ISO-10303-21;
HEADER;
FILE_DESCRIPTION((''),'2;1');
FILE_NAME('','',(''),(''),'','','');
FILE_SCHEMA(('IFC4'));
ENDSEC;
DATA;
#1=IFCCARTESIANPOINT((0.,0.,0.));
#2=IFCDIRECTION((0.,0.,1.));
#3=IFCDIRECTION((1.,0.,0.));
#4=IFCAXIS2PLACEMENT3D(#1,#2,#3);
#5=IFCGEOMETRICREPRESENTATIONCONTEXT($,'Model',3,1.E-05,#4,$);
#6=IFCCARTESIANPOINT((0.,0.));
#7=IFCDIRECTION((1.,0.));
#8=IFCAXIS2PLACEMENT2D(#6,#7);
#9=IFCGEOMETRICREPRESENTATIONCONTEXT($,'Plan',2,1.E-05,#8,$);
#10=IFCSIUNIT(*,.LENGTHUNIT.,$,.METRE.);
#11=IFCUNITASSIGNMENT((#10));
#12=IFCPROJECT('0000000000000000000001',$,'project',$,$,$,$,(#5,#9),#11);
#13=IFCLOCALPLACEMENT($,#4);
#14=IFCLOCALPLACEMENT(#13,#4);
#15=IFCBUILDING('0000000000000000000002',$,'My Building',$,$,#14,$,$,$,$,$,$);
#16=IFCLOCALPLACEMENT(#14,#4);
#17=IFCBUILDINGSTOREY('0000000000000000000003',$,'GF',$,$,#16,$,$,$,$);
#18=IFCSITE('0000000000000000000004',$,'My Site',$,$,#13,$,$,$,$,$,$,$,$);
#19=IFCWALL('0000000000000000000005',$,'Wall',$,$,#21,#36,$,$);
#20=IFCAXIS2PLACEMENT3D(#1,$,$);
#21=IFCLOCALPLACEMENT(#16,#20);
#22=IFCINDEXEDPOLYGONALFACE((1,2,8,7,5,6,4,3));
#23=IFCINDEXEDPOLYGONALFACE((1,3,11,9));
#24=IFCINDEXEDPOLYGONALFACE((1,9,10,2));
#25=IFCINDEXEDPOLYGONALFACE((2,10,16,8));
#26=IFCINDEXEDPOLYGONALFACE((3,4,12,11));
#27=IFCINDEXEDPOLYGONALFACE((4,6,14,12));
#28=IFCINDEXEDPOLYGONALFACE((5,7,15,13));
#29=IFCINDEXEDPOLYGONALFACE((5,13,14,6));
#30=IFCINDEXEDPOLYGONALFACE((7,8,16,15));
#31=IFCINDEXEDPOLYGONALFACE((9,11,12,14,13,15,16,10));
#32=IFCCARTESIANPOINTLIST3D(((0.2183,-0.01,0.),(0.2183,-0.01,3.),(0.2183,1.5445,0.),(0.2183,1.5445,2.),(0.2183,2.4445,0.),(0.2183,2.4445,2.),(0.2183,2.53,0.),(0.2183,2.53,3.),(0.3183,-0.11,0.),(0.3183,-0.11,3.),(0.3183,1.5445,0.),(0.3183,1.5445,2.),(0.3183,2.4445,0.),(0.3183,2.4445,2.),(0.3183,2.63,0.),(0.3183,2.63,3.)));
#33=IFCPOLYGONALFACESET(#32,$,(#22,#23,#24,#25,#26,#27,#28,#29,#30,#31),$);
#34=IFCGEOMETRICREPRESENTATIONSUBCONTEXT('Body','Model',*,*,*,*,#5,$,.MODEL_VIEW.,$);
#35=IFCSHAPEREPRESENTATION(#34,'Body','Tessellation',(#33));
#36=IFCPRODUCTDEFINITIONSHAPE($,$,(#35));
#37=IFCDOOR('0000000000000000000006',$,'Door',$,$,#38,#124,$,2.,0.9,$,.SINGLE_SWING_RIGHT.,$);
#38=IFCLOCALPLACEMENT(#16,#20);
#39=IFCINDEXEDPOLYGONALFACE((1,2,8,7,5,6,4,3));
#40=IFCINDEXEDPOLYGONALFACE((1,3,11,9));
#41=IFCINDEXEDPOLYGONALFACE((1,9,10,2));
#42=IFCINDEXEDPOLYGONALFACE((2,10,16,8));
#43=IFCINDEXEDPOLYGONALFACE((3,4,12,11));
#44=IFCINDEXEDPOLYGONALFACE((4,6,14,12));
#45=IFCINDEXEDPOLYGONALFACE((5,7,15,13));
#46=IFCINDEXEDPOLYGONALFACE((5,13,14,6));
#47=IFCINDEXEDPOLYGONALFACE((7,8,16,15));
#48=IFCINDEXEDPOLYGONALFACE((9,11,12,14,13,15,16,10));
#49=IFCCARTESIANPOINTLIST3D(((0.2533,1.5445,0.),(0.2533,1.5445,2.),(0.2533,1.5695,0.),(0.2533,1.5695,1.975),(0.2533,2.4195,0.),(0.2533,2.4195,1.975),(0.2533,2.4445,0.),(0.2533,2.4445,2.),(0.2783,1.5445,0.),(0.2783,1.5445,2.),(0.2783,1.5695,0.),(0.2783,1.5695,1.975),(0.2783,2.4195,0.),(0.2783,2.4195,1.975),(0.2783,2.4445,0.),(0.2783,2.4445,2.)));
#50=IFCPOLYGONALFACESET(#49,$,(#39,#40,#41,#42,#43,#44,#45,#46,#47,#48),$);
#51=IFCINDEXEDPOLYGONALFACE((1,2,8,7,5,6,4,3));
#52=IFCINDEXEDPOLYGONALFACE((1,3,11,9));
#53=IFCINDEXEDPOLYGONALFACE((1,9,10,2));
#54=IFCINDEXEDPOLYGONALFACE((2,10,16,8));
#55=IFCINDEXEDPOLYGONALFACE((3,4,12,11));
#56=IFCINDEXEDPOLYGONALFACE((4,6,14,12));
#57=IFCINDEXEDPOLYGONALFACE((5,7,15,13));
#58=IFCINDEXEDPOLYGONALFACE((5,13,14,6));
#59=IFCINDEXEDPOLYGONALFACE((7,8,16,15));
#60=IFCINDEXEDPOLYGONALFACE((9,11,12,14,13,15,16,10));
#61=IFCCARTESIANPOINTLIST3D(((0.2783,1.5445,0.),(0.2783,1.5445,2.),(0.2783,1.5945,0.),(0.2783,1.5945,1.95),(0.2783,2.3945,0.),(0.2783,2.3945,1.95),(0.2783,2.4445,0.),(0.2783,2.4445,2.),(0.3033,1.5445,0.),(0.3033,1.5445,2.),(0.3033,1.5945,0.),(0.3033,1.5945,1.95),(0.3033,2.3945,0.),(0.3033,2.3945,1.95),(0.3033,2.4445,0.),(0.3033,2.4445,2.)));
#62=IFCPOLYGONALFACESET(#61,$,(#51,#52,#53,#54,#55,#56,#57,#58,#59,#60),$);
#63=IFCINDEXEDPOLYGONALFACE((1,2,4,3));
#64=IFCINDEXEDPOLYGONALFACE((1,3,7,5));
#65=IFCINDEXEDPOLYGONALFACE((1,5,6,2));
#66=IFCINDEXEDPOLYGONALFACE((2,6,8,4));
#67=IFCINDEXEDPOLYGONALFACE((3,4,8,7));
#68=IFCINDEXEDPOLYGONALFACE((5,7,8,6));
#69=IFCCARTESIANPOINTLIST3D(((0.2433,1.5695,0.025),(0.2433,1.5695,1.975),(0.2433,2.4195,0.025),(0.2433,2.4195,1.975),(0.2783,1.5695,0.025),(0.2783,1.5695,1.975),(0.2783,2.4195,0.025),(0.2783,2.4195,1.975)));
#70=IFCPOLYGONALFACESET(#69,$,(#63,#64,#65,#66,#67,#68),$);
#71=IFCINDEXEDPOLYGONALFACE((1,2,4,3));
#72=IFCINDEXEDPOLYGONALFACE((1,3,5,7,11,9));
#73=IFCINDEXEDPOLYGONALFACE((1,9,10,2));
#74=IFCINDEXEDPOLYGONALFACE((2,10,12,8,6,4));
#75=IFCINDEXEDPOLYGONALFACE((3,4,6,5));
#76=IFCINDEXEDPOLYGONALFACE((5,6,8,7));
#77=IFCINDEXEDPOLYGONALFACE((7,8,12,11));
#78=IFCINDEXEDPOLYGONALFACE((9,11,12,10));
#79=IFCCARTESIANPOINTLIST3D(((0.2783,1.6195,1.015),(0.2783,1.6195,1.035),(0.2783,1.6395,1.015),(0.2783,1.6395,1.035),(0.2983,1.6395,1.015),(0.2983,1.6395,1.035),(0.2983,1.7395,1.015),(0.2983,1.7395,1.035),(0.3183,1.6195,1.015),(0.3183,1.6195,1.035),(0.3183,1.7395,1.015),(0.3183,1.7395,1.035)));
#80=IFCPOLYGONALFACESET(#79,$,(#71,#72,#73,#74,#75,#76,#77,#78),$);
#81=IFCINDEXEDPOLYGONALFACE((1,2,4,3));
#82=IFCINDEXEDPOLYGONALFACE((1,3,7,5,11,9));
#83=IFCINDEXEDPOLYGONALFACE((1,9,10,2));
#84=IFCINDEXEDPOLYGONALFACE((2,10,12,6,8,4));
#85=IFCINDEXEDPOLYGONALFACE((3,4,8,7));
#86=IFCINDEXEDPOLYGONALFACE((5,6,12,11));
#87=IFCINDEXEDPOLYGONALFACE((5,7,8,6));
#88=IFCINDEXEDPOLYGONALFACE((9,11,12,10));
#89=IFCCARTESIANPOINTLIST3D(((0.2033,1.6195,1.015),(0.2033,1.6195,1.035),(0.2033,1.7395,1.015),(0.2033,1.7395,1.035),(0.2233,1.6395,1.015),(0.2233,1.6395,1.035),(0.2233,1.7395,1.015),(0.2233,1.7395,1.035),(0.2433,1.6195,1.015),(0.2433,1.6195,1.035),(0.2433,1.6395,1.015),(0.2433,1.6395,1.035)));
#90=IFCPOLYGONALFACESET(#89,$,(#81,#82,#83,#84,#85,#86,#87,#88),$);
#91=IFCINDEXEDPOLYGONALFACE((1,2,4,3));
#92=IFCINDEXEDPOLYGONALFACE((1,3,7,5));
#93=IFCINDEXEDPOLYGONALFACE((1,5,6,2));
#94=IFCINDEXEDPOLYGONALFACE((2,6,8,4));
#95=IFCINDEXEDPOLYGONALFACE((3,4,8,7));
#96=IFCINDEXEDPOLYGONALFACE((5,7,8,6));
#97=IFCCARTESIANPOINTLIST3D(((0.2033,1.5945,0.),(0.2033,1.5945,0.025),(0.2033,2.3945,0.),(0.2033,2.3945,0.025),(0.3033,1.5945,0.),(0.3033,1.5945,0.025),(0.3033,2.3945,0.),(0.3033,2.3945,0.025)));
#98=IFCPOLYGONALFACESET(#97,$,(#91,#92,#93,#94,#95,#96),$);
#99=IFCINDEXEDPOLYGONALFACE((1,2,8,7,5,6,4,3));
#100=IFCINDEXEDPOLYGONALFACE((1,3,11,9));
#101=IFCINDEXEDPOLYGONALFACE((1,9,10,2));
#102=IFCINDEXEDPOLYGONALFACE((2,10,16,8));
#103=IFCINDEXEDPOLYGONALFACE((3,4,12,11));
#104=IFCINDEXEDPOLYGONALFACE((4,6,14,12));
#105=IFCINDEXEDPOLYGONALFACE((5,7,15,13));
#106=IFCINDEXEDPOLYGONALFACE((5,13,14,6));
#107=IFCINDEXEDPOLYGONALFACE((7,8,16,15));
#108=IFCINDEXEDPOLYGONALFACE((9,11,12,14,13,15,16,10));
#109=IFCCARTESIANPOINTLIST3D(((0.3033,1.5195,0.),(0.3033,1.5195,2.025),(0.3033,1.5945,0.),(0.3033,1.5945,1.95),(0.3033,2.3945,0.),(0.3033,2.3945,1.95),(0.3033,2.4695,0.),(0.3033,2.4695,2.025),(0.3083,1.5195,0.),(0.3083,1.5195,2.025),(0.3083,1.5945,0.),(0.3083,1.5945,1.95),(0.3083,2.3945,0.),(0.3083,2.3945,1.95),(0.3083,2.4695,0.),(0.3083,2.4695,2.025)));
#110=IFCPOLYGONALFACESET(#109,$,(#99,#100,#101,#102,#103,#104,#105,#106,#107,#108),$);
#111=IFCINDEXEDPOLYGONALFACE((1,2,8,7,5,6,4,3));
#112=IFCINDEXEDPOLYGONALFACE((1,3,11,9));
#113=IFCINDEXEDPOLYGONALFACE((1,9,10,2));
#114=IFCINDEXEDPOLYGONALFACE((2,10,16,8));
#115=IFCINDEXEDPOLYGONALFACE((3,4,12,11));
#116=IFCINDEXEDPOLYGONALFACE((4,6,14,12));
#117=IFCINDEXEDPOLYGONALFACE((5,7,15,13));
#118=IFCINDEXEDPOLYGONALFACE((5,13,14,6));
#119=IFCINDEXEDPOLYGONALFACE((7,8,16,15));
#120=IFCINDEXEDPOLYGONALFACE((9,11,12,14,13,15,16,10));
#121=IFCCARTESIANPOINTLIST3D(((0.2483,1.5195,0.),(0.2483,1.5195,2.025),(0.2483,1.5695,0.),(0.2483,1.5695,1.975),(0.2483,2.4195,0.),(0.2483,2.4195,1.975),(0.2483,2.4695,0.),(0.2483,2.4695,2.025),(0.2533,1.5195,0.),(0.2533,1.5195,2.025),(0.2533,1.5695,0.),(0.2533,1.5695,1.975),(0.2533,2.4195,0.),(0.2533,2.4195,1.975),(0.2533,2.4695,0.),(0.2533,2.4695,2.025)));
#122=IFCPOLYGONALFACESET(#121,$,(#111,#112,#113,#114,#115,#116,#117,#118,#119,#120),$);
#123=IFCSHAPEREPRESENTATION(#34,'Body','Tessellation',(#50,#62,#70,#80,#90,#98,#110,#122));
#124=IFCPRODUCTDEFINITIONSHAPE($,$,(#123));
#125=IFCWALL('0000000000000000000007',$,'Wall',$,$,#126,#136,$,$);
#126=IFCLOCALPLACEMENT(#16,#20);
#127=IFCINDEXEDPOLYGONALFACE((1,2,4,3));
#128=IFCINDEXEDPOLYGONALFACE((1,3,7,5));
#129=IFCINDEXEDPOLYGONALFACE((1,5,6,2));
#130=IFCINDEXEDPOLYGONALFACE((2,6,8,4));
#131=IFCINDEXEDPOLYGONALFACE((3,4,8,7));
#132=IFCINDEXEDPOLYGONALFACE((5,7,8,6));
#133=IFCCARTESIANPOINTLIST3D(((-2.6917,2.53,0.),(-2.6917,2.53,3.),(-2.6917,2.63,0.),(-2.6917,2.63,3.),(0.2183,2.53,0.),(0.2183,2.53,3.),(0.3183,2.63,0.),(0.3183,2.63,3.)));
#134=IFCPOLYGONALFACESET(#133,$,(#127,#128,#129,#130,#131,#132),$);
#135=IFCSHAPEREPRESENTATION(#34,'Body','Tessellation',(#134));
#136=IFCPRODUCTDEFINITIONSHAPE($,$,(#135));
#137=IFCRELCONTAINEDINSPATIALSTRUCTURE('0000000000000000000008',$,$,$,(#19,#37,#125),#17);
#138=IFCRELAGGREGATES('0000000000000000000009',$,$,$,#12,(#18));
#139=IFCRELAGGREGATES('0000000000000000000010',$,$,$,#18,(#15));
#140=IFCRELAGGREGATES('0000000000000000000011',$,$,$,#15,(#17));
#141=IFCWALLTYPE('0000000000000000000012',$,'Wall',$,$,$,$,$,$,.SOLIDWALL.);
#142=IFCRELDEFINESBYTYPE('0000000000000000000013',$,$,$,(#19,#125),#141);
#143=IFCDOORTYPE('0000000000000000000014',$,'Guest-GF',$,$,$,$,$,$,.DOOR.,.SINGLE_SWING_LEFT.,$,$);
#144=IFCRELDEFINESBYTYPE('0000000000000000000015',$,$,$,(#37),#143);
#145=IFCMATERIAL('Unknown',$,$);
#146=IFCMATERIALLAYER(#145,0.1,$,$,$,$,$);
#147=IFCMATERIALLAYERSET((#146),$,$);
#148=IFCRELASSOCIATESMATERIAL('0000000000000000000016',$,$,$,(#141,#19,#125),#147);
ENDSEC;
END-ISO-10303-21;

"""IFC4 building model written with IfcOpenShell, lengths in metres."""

from ifc_helpers import new_model, entity, si_unit, frame, origin_with_axes, origin_2d_with_axis, place, context, subcontext, project, spatial, line, indexed_curve, outline, extrude, shape, source, transform, mapped, material, layer, layer_set, layer_usage, type_object, type_shapes, element, fill, save


model = new_model("IFC4")

# Units and contexts
model_context = context("Model", 3, precision=1e-05, world=origin_with_axes())
plan_context = context("Plan", 2, precision=1e-05, world=origin_2d_with_axis())
body_context_1 = subcontext(model_context, "Body", "Model", "MODEL_VIEW")
body_context_2 = subcontext(plan_context, "Body", "Plan", "PLAN_VIEW")
ifc_project = project(units=[si_unit("LENGTHUNIT", "METRE")], contexts=[model_context, plan_context])

# Site, building, storey
site_placement = place(None, origin_with_axes())
site = spatial("IfcSite", under=ifc_project, at=site_placement, Name="My Site")
building_placement = place(site_placement, origin_with_axes())
building = spatial("IfcBuilding", under=site, at=building_placement, Name="My Building")
storey_placement = place(building_placement, origin_with_axes())
storey = spatial("IfcBuildingStorey", under=building, at=storey_placement, Name="GF")

# Shared definitions
ifc_material = material(Name="Unknown")

# Shared definitions
ifc_layer_1 = layer(ifc_material, 0.1)
ifc_layer_set_1 = layer_set([ifc_layer_1])
wall_type = type_object("IfcWallType", Name="Wall", PredefinedType="SOLIDWALL", material=ifc_layer_set_1)

# Wall, opening, door
ifc_layer_usage_1 = layer_usage(ifc_layer_set_1, "AXIS2", "POSITIVE", 0.0)
wall_1_placement = place(storey_placement, frame((0.3183, -0.11, 0.0), z_axis=(0.0, 0.0, 1.0), x_axis=(0.0, 1.0, 0.0)))
wall_1 = element("IfcWall", 1, at=wall_1_placement, inside=storey, type_object=wall_type, material=ifc_layer_usage_1, Name="Wall", context=body_context_1, shape_type="SweptSolid", body=[
    extrude(outline(indexed_curve([(0.0, 0.0), (0.1, 0.1), (2.64, 0.1), (2.74, 0.0)], segments=[line(1, 2, 3, 4, 1)])), origin_with_axes(), (0.0, 0.0, 1.0), 3.0),
])
shared_shape_1 = source(origin_with_axes(), body_context_1, "Body", "SweptSolid", [
    extrude(outline(indexed_curve([(0.0, 0.0), (0.9, 0.0), (0.9, 2.0), (0.0, 2.0)], segments=[line(1, 2, 3, 4, 1)])), frame((0.0, -0.6, 0.0), z_axis=(0.0, -1.0, 0.0), x_axis=(1.0, 0.0, 0.0)), (0.0, 0.0, -1.0), 1.2),
])
opening_1_placement = place(wall_1_placement, frame((1.6545, 0.015, 0.0), z_axis=(0.0, 0.0, 1.0), x_axis=(1.0, 0.0, 0.0)))
opening_1 = element("IfcOpeningElement", 2, at=opening_1_placement, cuts=wall_1, PredefinedType="OPENING", context=body_context_1, shape_type="MappedRepresentation", body=[
    mapped(shared_shape_1, transform((0.0, 0.0, 0.0), x_axis=(1.0, 0.0, 0.0), y_axis=(0.0, 1.0, 0.0), z_axis=(0.0, 0.0, 1.0), scale=1.0)),
])
door_type_1 = type_object("IfcDoorType", Name="Guest-GF", OperationType="SINGLE_SWING_LEFT", PredefinedType="DOOR")
shared_shape_2 = source(origin_with_axes(), body_context_1, "Body", "SweptSolid", [
    extrude(outline(indexed_curve([(0.0, 0.0), (0.0, 2.0), (0.9, 2.0), (0.9, 0.0), (0.875, 0.0), (0.875, 1.975), (0.025, 1.975), (0.025, 0.0)], segments=[line(1, 2, 3, 4, 5, 6, 7, 8, 1)])), frame((0.0, 0.025, 0.0), z_axis=(0.0, -1.0, 0.0), x_axis=(1.0, 0.0, 0.0)), (0.0, 0.0, -1.0), 0.025),
    extrude(outline(indexed_curve([(0.0, 0.0), (0.0, 2.0), (0.9, 2.0), (0.9, 0.0), (0.85, 0.0), (0.85, 1.95), (0.05, 1.95), (0.05, 0.0)], segments=[line(1, 2, 3, 4, 5, 6, 7, 8, 1)])), frame((0.0, 0.0, 0.0), z_axis=(0.0, -1.0, 0.0), x_axis=(1.0, 0.0, 0.0)), (0.0, 0.0, -1.0), 0.025),
    extrude(outline(indexed_curve([(0.0, 0.0), (0.85, 0.0), (0.85, 0.035), (0.0, 0.035)], segments=[line(1, 2, 3, 4, 1)])), frame((0.025, 0.025, 0.025), z_axis=(0.0, 0.0, 1.0), x_axis=(1.0, 0.0, 0.0)), (0.0, 0.0, 1.0), 1.95),
    extrude(outline(indexed_curve([(0.0, 0.0), (0.0, -0.04), (0.12, -0.04), (0.12, -0.02), (0.02, -0.02), (0.02, 0.0)], segments=[line(1, 2, 3, 4, 5, 6, 1)])), frame((0.075, 0.025, 1.015), z_axis=(0.0, 0.0, 1.0), x_axis=(1.0, 0.0, 0.0)), (0.0, 0.0, 1.0), 0.02),
    extrude(outline(indexed_curve([(0.0, 0.0), (0.0, 0.04), (0.12, 0.04), (0.12, 0.02), (0.02, 0.02), (0.02, 0.0)], segments=[line(1, 2, 3, 4, 5, 6, 1)])), frame((0.075, 0.06, 1.015), z_axis=(0.0, 0.0, 1.0), x_axis=(1.0, 0.0, 0.0)), (0.0, 0.0, 1.0), 0.02),
    extrude(outline(indexed_curve([(0.0, 0.0), (0.8, 0.0), (0.8, 0.1), (0.0, 0.1)], segments=[line(1, 2, 3, 4, 1)])), frame((0.05, 0.0, 0.0), z_axis=(0.0, 0.0, 1.0), x_axis=(1.0, 0.0, 0.0)), (0.0, 0.0, 1.0), 0.025),
    extrude(outline(indexed_curve([(0.0, 0.0), (0.0, 2.025), (0.95, 2.025), (0.95, 0.0), (0.875, 0.0), (0.875, 1.95), (0.075, 1.95), (0.075, 0.0)], segments=[line(1, 2, 3, 4, 5, 6, 7, 8, 1)])), frame((-0.025, -0.005, 0.0), z_axis=(0.0, -1.0, 0.0), x_axis=(1.0, 0.0, 0.0)), (0.0, 0.0, -1.0), 0.005),
    extrude(outline(indexed_curve([(0.0, 0.0), (0.0, 2.025), (0.95, 2.025), (0.95, 0.0), (0.9, 0.0), (0.9, 1.975), (0.05, 1.975), (0.05, 0.0)], segments=[line(1, 2, 3, 4, 5, 6, 7, 8, 1)])), frame((-0.025, 0.05, 0.0), z_axis=(0.0, -1.0, 0.0), x_axis=(1.0, 0.0, 0.0)), (0.0, 0.0, -1.0), 0.005),
])
shared_shape_3 = source(origin_with_axes(), body_context_2, "Body", "Curve2D", [
    entity("IfcIndexedPolyCurve", entity("IfcCartesianPointList2D", [[0.0, 0.0], [0.0, 0.05], [0.025, 0.05], [0.025, 0.025], [0.05, 0.025], [0.05, 0.0]]), [entity("IfcLineIndex", [1, 2, 3, 4, 5, 6, 1])]),
    entity("IfcIndexedPolyCurve", entity("IfcCartesianPointList2D", [[0.9, 0.0], [0.9, 0.05], [0.875, 0.05], [0.875, 0.025], [0.85, 0.025], [0.85, 0.0]]), [entity("IfcLineIndex", [1, 2, 3, 4, 5, 6, 1])]),
    entity("IfcTrimmedCurve", entity("IfcEllipse", entity("IfcAxis2Placement2D", entity("IfcCartesianPoint", [0.84, 0.05]), entity("IfcDirection", [1.0, 0.0])), 0.815, 0.85), [entity("IfcCartesianPoint", [0.84, 0.9])], [entity("IfcCartesianPoint", [0.025, 0.05])], True, "CARTESIAN"),
    entity("IfcIndexedPolyCurve", entity("IfcCartesianPointList2D", [[0.875, 0.05], [0.84, 0.05], [0.84, 0.9], [0.875, 0.9]]), [entity("IfcLineIndex", [1, 2, 3, 4, 1])]),
])
type_shapes(door_type_1, [shared_shape_2, shared_shape_3])
door_1_placement = place(opening_1_placement, frame((0.0, 0.0, 0.0), z_axis=(0.0, 0.0, 1.0), x_axis=(1.0, 0.0, 0.0)))
door_1 = element("IfcDoor", 3, at=door_1_placement, inside=storey, type_object=door_type_1, Name="Door", OperationType="SINGLE_SWING_RIGHT", OverallHeight=2.0, OverallWidth=0.9, shapes=[
    shape(body_context_1, "Body", "MappedRepresentation", [mapped(shared_shape_2, transform((0.0, 0.0, 0.0), x_axis=(1.0, 0.0, 0.0), y_axis=(0.0, 1.0, 0.0), z_axis=(0.0, 0.0, 1.0), scale=1.0))]),
    shape(body_context_2, "Body", "MappedRepresentation", [mapped(shared_shape_3, transform((0.0, 0.0, 0.0), x_axis=(1.0, 0.0, 0.0), y_axis=(0.0, 1.0, 0.0), z_axis=(0.0, 0.0, 1.0), scale=1.0))]),
])
fill(opening_1, door_1)

# Wall
ifc_layer_usage_2 = layer_usage(ifc_layer_set_1, "AXIS2", "POSITIVE", 0.0)
wall_2_placement = place(storey_placement, frame((0.3183, 2.63, 0.0), z_axis=(0.0, 0.0, 1.0), x_axis=(-1.0, 0.0, 0.0)))
element("IfcWall", 4, at=wall_2_placement, inside=storey, type_object=wall_type, material=ifc_layer_usage_2, Name="Wall", context=body_context_1, shape_type="SweptSolid", body=[
    extrude(outline(indexed_curve([(0.0, 0.0), (0.1, 0.1), (3.01, 0.1), (3.01, 0.0)], segments=[line(1, 2, 3, 4, 1)])), origin_with_axes(), (0.0, 0.0, 1.0), 3.0),
])

save(model, "model.ifc")
